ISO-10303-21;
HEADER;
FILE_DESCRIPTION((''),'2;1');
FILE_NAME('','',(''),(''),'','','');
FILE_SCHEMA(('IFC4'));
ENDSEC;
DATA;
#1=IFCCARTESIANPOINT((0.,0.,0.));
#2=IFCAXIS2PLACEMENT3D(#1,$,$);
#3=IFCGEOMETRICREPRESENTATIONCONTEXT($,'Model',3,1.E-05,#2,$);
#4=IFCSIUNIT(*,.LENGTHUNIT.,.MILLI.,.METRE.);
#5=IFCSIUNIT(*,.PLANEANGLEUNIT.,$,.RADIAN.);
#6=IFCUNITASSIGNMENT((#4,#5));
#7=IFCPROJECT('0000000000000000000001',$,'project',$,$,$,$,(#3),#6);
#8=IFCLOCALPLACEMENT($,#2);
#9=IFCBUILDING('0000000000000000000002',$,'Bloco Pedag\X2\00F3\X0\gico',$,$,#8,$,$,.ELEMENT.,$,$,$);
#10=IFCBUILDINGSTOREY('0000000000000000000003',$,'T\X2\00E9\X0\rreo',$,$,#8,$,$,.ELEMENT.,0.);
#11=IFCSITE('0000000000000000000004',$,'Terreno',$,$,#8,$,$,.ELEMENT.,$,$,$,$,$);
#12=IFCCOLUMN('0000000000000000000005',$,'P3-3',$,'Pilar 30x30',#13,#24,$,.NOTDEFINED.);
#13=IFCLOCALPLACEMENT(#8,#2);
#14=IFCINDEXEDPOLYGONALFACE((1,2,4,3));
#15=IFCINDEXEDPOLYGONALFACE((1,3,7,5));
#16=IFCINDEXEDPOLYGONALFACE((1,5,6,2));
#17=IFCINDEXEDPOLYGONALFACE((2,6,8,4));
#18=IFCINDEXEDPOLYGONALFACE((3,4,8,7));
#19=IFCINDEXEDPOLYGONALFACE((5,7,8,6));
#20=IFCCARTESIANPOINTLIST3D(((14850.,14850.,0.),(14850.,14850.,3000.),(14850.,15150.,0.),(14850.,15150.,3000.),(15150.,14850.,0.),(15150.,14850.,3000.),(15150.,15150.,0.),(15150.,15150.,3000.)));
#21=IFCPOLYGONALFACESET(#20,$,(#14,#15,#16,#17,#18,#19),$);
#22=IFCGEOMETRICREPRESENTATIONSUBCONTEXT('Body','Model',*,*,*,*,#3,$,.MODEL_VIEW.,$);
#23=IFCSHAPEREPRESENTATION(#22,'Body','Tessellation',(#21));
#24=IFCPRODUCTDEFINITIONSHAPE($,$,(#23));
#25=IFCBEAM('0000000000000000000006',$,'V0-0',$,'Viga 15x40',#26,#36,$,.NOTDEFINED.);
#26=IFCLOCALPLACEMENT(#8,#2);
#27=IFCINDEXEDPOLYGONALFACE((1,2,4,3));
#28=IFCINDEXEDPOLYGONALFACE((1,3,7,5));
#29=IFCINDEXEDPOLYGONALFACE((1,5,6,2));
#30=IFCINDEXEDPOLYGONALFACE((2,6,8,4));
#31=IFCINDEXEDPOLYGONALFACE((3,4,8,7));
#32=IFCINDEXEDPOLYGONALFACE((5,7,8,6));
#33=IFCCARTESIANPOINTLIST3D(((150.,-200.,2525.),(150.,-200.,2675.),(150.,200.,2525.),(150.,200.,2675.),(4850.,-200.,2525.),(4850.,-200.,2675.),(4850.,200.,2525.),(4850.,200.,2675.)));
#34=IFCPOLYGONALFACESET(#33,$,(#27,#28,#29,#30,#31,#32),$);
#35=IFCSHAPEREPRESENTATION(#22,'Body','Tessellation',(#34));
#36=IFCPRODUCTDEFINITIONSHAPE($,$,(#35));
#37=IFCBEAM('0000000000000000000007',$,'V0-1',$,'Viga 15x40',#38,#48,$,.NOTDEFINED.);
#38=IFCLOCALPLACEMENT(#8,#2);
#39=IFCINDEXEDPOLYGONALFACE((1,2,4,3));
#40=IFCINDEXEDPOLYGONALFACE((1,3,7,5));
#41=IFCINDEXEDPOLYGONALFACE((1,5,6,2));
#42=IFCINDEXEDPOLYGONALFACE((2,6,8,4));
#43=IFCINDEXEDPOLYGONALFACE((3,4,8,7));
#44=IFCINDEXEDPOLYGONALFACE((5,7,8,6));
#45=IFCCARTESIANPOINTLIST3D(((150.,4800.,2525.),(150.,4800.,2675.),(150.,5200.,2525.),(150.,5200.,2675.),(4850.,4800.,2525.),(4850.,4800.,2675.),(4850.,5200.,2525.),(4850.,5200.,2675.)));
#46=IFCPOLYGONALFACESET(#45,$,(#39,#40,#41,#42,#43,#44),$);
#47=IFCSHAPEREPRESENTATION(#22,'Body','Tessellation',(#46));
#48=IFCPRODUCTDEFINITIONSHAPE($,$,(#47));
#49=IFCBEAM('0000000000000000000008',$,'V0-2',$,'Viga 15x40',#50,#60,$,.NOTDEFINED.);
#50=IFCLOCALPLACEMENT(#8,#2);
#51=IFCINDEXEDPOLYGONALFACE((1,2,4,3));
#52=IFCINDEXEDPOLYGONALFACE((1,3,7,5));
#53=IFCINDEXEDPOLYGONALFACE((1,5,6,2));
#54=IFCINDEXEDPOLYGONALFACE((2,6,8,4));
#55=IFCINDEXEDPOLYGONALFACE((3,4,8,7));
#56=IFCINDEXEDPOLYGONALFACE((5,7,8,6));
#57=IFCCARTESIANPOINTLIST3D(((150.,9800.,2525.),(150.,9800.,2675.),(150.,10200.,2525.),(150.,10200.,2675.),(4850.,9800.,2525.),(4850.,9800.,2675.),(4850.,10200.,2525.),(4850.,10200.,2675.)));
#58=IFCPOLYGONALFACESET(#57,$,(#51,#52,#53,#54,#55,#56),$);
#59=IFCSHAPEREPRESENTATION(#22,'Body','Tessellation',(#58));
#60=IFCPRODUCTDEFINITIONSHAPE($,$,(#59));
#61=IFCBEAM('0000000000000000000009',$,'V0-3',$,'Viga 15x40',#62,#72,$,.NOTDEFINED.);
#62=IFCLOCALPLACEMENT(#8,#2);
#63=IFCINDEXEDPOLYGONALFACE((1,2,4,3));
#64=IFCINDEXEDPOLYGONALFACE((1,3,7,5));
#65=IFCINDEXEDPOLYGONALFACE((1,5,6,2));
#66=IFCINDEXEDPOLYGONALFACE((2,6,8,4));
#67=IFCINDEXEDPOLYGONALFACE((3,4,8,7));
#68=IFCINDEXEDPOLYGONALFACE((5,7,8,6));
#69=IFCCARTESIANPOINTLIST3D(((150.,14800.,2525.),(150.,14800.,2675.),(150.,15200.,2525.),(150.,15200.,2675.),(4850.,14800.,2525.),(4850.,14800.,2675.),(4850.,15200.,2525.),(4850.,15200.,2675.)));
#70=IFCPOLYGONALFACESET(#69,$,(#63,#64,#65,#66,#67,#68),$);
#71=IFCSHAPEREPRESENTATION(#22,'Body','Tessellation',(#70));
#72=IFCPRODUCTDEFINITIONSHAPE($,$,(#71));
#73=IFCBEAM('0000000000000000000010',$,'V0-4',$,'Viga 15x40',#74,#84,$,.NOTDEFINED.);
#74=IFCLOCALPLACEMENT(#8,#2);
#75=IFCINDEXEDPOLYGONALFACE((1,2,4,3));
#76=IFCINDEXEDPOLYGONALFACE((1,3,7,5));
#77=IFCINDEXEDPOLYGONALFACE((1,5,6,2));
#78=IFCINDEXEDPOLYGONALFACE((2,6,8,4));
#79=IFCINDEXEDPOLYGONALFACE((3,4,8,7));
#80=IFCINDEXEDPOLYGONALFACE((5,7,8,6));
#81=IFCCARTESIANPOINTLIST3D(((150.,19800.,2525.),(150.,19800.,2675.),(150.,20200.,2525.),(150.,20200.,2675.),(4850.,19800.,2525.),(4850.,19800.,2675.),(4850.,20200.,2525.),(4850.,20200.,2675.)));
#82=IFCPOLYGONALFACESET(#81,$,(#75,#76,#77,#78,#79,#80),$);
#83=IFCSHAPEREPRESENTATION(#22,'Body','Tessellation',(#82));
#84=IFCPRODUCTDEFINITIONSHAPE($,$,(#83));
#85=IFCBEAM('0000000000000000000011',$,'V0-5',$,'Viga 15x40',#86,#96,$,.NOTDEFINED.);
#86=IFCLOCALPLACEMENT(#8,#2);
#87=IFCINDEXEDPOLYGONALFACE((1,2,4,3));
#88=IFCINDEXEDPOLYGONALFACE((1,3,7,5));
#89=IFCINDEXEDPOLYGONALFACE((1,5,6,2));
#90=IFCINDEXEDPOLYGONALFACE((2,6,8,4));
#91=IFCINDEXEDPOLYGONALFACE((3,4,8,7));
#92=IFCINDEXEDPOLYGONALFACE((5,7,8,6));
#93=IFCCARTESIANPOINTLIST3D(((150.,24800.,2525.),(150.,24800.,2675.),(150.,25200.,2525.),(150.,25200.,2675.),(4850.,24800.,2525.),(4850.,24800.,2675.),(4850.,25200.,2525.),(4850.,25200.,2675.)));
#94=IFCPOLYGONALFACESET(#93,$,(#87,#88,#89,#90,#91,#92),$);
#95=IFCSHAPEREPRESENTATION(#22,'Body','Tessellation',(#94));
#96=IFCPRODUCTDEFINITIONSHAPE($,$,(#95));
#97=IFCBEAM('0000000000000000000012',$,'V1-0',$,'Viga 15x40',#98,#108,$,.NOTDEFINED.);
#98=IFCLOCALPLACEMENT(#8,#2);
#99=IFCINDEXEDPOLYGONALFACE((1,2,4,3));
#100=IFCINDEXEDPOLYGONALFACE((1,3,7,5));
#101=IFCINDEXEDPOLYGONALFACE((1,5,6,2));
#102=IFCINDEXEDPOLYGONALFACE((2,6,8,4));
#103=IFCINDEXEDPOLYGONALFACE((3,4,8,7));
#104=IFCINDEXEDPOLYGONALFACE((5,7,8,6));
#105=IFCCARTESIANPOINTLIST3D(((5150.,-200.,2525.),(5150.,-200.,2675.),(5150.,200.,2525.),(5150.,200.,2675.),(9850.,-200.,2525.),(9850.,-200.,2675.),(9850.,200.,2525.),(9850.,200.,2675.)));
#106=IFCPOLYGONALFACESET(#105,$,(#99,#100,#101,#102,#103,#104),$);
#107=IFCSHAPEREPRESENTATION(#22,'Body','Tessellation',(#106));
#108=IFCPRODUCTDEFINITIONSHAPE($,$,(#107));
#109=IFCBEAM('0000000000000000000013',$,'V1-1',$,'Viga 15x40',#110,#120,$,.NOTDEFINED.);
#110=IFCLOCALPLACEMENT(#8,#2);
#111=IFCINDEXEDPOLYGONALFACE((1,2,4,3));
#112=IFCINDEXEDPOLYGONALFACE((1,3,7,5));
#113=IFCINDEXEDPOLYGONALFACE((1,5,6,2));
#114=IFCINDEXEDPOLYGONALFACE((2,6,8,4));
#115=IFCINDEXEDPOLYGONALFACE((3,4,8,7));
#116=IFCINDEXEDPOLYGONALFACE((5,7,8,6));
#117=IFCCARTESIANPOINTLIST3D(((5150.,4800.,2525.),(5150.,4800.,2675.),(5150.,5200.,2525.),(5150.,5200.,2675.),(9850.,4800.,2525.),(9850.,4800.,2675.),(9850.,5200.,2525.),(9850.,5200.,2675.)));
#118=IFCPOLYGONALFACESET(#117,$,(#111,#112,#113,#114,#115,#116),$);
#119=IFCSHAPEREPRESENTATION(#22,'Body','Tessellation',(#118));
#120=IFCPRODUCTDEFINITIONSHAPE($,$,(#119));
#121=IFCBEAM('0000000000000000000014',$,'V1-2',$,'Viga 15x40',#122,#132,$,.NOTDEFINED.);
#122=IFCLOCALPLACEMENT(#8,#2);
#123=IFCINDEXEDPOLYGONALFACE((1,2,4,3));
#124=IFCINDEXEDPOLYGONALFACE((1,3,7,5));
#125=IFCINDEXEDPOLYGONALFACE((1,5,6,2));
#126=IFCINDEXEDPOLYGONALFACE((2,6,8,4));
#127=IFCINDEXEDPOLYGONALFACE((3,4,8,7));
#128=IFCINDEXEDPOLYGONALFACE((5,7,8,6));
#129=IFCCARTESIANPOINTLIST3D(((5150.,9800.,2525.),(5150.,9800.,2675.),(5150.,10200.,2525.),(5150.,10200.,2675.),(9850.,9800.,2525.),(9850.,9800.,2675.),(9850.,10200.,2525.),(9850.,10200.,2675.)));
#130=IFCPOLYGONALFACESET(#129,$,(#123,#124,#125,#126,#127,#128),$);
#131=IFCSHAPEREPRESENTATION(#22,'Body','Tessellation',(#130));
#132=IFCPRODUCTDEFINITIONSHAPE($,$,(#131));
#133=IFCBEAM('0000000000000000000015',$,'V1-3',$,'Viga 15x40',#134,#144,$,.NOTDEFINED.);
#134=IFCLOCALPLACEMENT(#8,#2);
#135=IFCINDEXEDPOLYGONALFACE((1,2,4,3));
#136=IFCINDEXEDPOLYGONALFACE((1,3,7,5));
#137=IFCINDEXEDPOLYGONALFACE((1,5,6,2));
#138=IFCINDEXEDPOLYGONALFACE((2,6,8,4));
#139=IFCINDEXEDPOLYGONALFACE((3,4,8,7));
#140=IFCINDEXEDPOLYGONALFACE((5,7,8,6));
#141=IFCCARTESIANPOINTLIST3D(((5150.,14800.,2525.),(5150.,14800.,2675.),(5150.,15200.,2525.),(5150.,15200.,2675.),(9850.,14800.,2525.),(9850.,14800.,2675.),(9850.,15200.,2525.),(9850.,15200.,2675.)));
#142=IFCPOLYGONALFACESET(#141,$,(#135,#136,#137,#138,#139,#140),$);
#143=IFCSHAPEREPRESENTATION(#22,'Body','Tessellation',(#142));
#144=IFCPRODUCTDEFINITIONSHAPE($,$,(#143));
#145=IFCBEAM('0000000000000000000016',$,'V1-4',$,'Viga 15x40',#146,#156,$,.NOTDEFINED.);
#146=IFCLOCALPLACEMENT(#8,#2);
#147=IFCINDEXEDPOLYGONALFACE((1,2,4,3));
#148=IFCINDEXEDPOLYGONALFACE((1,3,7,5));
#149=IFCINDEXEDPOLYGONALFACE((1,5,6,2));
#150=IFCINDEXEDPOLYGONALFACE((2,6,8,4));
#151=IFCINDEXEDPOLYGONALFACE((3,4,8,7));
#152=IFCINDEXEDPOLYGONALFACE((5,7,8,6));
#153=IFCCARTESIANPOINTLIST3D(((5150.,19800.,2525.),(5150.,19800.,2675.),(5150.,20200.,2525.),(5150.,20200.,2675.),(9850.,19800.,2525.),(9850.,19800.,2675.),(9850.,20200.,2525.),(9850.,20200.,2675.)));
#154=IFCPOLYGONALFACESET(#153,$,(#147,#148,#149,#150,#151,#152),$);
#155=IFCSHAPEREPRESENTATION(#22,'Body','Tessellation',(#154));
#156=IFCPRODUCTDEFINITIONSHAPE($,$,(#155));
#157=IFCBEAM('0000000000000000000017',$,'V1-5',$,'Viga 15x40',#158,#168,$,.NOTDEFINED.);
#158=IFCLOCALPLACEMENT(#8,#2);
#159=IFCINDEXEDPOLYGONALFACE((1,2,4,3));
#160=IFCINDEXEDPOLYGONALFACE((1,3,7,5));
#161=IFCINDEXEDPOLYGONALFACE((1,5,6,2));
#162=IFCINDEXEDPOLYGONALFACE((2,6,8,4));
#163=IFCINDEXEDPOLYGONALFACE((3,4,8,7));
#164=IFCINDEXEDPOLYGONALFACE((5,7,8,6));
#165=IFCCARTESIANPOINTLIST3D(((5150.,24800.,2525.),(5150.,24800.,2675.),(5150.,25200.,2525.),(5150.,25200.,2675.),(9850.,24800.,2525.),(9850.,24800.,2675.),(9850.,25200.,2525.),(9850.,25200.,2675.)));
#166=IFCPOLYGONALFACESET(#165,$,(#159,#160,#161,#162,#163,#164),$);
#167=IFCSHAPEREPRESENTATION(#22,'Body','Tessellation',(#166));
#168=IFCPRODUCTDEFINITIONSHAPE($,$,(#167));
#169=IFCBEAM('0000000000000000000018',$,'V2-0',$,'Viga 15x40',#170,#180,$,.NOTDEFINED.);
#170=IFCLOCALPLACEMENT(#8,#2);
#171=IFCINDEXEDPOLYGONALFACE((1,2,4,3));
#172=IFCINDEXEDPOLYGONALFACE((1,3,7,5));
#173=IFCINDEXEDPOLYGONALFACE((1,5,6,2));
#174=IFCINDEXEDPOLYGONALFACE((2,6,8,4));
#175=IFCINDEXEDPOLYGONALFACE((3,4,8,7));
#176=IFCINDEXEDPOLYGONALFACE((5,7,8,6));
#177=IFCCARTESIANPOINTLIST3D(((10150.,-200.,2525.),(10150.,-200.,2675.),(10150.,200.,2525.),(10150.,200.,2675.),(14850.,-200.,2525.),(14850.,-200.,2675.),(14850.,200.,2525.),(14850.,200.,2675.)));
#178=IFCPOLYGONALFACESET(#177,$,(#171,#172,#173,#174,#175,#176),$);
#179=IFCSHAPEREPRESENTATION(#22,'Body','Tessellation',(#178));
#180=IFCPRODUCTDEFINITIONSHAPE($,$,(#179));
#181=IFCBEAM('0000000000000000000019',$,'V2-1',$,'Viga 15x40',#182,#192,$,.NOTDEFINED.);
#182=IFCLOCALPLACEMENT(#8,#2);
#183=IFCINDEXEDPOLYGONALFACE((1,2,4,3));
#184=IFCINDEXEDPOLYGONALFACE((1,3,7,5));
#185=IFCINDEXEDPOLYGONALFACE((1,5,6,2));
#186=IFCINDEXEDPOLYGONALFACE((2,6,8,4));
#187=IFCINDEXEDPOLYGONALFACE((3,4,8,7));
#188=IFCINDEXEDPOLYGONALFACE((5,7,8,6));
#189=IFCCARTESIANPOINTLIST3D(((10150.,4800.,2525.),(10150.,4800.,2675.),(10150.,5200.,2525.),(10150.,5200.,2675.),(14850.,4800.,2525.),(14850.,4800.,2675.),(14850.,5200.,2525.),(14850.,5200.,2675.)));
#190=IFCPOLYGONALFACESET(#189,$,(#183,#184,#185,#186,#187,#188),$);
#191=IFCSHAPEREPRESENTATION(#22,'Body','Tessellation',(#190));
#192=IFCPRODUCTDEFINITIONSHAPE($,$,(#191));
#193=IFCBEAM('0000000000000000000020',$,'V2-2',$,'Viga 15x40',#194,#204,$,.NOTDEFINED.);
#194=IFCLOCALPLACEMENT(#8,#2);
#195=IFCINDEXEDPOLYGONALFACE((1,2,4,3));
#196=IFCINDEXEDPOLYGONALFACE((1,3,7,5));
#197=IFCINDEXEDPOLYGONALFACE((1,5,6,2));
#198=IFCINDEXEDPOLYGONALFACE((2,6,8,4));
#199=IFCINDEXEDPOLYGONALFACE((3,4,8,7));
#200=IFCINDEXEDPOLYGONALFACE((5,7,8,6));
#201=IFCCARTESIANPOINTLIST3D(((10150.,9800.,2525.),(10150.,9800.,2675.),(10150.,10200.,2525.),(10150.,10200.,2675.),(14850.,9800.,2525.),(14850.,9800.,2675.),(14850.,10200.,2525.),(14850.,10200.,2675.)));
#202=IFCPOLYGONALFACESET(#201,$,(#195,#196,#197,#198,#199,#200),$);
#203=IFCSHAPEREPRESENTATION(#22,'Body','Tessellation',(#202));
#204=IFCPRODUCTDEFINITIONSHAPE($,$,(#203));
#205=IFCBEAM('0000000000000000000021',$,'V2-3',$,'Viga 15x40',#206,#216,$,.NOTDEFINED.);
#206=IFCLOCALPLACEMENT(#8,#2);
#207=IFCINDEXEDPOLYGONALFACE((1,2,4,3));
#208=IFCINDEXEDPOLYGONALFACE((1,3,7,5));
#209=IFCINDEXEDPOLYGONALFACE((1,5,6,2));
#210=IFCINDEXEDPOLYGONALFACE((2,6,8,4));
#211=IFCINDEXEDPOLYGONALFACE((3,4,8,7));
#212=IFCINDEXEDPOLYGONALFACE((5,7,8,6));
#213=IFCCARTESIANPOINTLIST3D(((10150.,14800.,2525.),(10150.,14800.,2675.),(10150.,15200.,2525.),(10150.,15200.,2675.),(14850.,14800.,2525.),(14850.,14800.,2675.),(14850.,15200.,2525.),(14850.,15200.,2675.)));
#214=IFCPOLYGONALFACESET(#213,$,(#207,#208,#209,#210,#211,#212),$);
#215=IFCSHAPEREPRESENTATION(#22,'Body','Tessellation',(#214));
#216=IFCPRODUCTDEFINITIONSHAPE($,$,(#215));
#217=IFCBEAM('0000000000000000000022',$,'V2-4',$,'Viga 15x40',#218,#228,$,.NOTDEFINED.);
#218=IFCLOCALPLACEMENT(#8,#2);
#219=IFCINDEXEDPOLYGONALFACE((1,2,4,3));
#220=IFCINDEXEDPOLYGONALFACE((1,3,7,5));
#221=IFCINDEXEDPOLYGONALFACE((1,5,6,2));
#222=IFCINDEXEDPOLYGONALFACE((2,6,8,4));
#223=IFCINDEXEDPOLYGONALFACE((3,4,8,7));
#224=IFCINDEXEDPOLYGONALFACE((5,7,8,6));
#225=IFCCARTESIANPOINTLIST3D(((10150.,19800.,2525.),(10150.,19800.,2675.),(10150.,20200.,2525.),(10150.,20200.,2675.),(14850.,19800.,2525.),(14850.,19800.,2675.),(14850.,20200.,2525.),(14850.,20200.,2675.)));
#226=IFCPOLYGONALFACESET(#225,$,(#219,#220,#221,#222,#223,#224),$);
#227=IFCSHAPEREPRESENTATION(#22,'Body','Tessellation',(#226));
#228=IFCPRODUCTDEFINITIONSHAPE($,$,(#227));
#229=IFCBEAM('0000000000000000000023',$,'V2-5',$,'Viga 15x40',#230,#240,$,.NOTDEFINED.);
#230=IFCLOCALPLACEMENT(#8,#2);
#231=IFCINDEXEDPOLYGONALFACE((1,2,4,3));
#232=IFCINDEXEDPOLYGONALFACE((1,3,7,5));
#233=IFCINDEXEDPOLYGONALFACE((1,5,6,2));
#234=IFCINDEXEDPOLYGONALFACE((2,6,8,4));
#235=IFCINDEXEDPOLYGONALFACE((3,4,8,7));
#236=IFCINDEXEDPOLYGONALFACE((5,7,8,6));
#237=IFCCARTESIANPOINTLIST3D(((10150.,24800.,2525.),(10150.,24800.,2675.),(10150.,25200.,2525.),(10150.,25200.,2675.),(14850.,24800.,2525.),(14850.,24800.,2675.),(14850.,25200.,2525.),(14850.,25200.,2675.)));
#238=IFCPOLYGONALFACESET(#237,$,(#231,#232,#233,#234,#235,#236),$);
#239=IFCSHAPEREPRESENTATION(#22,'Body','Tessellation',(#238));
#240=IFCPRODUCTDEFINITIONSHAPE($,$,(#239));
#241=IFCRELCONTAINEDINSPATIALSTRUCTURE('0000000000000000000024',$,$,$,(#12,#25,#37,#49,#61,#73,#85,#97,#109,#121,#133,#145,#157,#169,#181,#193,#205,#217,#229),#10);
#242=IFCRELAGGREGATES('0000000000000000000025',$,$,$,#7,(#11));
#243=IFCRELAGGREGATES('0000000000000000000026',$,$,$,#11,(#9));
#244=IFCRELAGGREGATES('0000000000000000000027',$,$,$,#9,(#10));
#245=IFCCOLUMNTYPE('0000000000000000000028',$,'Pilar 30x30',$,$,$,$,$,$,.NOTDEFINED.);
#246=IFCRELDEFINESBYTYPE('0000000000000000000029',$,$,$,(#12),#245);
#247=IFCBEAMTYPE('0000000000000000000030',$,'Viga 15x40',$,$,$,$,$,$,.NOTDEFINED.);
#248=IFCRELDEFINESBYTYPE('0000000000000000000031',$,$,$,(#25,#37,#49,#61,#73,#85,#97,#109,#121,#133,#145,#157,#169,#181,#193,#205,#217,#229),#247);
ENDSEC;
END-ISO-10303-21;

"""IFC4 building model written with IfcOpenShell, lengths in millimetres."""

from ifc_helpers import new_model, si_unit, frame, origin, origin_2d, place, context, subcontext, project, spatial, rectangle, extrude, type_object, element, save


model = new_model("IFC4")

# Units and contexts
model_context = context("Model", 3, precision=1e-05, world=origin())
body_context = subcontext(model_context, "Body", "Model", "MODEL_VIEW")
ifc_project = project(units=[si_unit("LENGTHUNIT", "METRE", prefix="MILLI"), si_unit("PLANEANGLEUNIT", "RADIAN")], contexts=[model_context])

# Site, building, storey
placement = place(None, origin())
site = spatial("IfcSite", under=ifc_project, at=placement, Name="Terreno", CompositionType="ELEMENT")
building = spatial("IfcBuilding", under=site, at=placement, Name="Bloco Pedagógico", CompositionType="ELEMENT")
storey = spatial("IfcBuildingStorey", under=building, at=placement, Name="Térreo", CompositionType="ELEMENT", Elevation=0.0)

# Column
column_type = type_object("IfcColumnType", Name="Pilar 30x30", PredefinedType="NOTDEFINED")
for number, where, z_axis, x_axis, name in (
    (1, (15000.0, 15000.0, 0.0), (0.0, 0.0, 1.0), (1.0, 0.0, 0.0), "P3-3"),
):
    element("IfcColumn", number, at=place(None, frame(where, z_axis=z_axis, x_axis=x_axis)), inside=storey, type_object=column_type, Name=name, ObjectType="Pilar 30x30", PredefinedType="NOTDEFINED", context=body_context, shape_type="SweptSolid", body=[
        extrude(rectangle(XDim=300.0, YDim=300.0, at=origin_2d()), None, (0.0, 0.0, 1.0), 3000.0),
    ])

# Beams
beam_type = type_object("IfcBeamType", Name="Viga 15x40", PredefinedType="NOTDEFINED")
for number, where, z_axis, x_axis, name in (
    (2, (150.0, 0.0, 2600.0), (1.0, 0.0, 0.0), (0.0, 1.0, 0.0), "V0-0"),
    (3, (150.0, 5000.0, 2600.0), (1.0, 0.0, 0.0), (0.0, 1.0, 0.0), "V0-1"),
    (4, (150.0, 10000.0, 2600.0), (1.0, 0.0, 0.0), (0.0, 1.0, 0.0), "V0-2"),
    (5, (150.0, 15000.0, 2600.0), (1.0, 0.0, 0.0), (0.0, 1.0, 0.0), "V0-3"),
    (6, (150.0, 20000.0, 2600.0), (1.0, 0.0, 0.0), (0.0, 1.0, 0.0), "V0-4"),
    (7, (150.0, 25000.0, 2600.0), (1.0, 0.0, 0.0), (0.0, 1.0, 0.0), "V0-5"),
    (8, (5150.0, 0.0, 2600.0), (1.0, 0.0, 0.0), (0.0, 1.0, 0.0), "V1-0"),
    (9, (5150.0, 5000.0, 2600.0), (1.0, 0.0, 0.0), (0.0, 1.0, 0.0), "V1-1"),
    (10, (5150.0, 10000.0, 2600.0), (1.0, 0.0, 0.0), (0.0, 1.0, 0.0), "V1-2"),
    (11, (5150.0, 15000.0, 2600.0), (1.0, 0.0, 0.0), (0.0, 1.0, 0.0), "V1-3"),
    (12, (5150.0, 20000.0, 2600.0), (1.0, 0.0, 0.0), (0.0, 1.0, 0.0), "V1-4"),
    (13, (5150.0, 25000.0, 2600.0), (1.0, 0.0, 0.0), (0.0, 1.0, 0.0), "V1-5"),
    (14, (10150.0, 0.0, 2600.0), (1.0, 0.0, 0.0), (0.0, 1.0, 0.0), "V2-0"),
    (15, (10150.0, 5000.0, 2600.0), (1.0, 0.0, 0.0), (0.0, 1.0, 0.0), "V2-1"),
    (16, (10150.0, 10000.0, 2600.0), (1.0, 0.0, 0.0), (0.0, 1.0, 0.0), "V2-2"),
    (17, (10150.0, 15000.0, 2600.0), (1.0, 0.0, 0.0), (0.0, 1.0, 0.0), "V2-3"),
    (18, (10150.0, 20000.0, 2600.0), (1.0, 0.0, 0.0), (0.0, 1.0, 0.0), "V2-4"),
    (19, (10150.0, 25000.0, 2600.0), (1.0, 0.0, 0.0), (0.0, 1.0, 0.0), "V2-5"),
):
    element("IfcBeam", number, at=place(None, frame(where, z_axis=z_axis, x_axis=x_axis)), inside=storey, type_object=beam_type, Name=name, ObjectType="Viga 15x40", PredefinedType="NOTDEFINED", context=body_context, shape_type="SweptSolid", body=[
        extrude(rectangle(XDim=400.0, YDim=150.0, at=origin_2d()), None, (0.0, 0.0, 1.0), 4700.0),
    ])

save(model, "model.ifc")
